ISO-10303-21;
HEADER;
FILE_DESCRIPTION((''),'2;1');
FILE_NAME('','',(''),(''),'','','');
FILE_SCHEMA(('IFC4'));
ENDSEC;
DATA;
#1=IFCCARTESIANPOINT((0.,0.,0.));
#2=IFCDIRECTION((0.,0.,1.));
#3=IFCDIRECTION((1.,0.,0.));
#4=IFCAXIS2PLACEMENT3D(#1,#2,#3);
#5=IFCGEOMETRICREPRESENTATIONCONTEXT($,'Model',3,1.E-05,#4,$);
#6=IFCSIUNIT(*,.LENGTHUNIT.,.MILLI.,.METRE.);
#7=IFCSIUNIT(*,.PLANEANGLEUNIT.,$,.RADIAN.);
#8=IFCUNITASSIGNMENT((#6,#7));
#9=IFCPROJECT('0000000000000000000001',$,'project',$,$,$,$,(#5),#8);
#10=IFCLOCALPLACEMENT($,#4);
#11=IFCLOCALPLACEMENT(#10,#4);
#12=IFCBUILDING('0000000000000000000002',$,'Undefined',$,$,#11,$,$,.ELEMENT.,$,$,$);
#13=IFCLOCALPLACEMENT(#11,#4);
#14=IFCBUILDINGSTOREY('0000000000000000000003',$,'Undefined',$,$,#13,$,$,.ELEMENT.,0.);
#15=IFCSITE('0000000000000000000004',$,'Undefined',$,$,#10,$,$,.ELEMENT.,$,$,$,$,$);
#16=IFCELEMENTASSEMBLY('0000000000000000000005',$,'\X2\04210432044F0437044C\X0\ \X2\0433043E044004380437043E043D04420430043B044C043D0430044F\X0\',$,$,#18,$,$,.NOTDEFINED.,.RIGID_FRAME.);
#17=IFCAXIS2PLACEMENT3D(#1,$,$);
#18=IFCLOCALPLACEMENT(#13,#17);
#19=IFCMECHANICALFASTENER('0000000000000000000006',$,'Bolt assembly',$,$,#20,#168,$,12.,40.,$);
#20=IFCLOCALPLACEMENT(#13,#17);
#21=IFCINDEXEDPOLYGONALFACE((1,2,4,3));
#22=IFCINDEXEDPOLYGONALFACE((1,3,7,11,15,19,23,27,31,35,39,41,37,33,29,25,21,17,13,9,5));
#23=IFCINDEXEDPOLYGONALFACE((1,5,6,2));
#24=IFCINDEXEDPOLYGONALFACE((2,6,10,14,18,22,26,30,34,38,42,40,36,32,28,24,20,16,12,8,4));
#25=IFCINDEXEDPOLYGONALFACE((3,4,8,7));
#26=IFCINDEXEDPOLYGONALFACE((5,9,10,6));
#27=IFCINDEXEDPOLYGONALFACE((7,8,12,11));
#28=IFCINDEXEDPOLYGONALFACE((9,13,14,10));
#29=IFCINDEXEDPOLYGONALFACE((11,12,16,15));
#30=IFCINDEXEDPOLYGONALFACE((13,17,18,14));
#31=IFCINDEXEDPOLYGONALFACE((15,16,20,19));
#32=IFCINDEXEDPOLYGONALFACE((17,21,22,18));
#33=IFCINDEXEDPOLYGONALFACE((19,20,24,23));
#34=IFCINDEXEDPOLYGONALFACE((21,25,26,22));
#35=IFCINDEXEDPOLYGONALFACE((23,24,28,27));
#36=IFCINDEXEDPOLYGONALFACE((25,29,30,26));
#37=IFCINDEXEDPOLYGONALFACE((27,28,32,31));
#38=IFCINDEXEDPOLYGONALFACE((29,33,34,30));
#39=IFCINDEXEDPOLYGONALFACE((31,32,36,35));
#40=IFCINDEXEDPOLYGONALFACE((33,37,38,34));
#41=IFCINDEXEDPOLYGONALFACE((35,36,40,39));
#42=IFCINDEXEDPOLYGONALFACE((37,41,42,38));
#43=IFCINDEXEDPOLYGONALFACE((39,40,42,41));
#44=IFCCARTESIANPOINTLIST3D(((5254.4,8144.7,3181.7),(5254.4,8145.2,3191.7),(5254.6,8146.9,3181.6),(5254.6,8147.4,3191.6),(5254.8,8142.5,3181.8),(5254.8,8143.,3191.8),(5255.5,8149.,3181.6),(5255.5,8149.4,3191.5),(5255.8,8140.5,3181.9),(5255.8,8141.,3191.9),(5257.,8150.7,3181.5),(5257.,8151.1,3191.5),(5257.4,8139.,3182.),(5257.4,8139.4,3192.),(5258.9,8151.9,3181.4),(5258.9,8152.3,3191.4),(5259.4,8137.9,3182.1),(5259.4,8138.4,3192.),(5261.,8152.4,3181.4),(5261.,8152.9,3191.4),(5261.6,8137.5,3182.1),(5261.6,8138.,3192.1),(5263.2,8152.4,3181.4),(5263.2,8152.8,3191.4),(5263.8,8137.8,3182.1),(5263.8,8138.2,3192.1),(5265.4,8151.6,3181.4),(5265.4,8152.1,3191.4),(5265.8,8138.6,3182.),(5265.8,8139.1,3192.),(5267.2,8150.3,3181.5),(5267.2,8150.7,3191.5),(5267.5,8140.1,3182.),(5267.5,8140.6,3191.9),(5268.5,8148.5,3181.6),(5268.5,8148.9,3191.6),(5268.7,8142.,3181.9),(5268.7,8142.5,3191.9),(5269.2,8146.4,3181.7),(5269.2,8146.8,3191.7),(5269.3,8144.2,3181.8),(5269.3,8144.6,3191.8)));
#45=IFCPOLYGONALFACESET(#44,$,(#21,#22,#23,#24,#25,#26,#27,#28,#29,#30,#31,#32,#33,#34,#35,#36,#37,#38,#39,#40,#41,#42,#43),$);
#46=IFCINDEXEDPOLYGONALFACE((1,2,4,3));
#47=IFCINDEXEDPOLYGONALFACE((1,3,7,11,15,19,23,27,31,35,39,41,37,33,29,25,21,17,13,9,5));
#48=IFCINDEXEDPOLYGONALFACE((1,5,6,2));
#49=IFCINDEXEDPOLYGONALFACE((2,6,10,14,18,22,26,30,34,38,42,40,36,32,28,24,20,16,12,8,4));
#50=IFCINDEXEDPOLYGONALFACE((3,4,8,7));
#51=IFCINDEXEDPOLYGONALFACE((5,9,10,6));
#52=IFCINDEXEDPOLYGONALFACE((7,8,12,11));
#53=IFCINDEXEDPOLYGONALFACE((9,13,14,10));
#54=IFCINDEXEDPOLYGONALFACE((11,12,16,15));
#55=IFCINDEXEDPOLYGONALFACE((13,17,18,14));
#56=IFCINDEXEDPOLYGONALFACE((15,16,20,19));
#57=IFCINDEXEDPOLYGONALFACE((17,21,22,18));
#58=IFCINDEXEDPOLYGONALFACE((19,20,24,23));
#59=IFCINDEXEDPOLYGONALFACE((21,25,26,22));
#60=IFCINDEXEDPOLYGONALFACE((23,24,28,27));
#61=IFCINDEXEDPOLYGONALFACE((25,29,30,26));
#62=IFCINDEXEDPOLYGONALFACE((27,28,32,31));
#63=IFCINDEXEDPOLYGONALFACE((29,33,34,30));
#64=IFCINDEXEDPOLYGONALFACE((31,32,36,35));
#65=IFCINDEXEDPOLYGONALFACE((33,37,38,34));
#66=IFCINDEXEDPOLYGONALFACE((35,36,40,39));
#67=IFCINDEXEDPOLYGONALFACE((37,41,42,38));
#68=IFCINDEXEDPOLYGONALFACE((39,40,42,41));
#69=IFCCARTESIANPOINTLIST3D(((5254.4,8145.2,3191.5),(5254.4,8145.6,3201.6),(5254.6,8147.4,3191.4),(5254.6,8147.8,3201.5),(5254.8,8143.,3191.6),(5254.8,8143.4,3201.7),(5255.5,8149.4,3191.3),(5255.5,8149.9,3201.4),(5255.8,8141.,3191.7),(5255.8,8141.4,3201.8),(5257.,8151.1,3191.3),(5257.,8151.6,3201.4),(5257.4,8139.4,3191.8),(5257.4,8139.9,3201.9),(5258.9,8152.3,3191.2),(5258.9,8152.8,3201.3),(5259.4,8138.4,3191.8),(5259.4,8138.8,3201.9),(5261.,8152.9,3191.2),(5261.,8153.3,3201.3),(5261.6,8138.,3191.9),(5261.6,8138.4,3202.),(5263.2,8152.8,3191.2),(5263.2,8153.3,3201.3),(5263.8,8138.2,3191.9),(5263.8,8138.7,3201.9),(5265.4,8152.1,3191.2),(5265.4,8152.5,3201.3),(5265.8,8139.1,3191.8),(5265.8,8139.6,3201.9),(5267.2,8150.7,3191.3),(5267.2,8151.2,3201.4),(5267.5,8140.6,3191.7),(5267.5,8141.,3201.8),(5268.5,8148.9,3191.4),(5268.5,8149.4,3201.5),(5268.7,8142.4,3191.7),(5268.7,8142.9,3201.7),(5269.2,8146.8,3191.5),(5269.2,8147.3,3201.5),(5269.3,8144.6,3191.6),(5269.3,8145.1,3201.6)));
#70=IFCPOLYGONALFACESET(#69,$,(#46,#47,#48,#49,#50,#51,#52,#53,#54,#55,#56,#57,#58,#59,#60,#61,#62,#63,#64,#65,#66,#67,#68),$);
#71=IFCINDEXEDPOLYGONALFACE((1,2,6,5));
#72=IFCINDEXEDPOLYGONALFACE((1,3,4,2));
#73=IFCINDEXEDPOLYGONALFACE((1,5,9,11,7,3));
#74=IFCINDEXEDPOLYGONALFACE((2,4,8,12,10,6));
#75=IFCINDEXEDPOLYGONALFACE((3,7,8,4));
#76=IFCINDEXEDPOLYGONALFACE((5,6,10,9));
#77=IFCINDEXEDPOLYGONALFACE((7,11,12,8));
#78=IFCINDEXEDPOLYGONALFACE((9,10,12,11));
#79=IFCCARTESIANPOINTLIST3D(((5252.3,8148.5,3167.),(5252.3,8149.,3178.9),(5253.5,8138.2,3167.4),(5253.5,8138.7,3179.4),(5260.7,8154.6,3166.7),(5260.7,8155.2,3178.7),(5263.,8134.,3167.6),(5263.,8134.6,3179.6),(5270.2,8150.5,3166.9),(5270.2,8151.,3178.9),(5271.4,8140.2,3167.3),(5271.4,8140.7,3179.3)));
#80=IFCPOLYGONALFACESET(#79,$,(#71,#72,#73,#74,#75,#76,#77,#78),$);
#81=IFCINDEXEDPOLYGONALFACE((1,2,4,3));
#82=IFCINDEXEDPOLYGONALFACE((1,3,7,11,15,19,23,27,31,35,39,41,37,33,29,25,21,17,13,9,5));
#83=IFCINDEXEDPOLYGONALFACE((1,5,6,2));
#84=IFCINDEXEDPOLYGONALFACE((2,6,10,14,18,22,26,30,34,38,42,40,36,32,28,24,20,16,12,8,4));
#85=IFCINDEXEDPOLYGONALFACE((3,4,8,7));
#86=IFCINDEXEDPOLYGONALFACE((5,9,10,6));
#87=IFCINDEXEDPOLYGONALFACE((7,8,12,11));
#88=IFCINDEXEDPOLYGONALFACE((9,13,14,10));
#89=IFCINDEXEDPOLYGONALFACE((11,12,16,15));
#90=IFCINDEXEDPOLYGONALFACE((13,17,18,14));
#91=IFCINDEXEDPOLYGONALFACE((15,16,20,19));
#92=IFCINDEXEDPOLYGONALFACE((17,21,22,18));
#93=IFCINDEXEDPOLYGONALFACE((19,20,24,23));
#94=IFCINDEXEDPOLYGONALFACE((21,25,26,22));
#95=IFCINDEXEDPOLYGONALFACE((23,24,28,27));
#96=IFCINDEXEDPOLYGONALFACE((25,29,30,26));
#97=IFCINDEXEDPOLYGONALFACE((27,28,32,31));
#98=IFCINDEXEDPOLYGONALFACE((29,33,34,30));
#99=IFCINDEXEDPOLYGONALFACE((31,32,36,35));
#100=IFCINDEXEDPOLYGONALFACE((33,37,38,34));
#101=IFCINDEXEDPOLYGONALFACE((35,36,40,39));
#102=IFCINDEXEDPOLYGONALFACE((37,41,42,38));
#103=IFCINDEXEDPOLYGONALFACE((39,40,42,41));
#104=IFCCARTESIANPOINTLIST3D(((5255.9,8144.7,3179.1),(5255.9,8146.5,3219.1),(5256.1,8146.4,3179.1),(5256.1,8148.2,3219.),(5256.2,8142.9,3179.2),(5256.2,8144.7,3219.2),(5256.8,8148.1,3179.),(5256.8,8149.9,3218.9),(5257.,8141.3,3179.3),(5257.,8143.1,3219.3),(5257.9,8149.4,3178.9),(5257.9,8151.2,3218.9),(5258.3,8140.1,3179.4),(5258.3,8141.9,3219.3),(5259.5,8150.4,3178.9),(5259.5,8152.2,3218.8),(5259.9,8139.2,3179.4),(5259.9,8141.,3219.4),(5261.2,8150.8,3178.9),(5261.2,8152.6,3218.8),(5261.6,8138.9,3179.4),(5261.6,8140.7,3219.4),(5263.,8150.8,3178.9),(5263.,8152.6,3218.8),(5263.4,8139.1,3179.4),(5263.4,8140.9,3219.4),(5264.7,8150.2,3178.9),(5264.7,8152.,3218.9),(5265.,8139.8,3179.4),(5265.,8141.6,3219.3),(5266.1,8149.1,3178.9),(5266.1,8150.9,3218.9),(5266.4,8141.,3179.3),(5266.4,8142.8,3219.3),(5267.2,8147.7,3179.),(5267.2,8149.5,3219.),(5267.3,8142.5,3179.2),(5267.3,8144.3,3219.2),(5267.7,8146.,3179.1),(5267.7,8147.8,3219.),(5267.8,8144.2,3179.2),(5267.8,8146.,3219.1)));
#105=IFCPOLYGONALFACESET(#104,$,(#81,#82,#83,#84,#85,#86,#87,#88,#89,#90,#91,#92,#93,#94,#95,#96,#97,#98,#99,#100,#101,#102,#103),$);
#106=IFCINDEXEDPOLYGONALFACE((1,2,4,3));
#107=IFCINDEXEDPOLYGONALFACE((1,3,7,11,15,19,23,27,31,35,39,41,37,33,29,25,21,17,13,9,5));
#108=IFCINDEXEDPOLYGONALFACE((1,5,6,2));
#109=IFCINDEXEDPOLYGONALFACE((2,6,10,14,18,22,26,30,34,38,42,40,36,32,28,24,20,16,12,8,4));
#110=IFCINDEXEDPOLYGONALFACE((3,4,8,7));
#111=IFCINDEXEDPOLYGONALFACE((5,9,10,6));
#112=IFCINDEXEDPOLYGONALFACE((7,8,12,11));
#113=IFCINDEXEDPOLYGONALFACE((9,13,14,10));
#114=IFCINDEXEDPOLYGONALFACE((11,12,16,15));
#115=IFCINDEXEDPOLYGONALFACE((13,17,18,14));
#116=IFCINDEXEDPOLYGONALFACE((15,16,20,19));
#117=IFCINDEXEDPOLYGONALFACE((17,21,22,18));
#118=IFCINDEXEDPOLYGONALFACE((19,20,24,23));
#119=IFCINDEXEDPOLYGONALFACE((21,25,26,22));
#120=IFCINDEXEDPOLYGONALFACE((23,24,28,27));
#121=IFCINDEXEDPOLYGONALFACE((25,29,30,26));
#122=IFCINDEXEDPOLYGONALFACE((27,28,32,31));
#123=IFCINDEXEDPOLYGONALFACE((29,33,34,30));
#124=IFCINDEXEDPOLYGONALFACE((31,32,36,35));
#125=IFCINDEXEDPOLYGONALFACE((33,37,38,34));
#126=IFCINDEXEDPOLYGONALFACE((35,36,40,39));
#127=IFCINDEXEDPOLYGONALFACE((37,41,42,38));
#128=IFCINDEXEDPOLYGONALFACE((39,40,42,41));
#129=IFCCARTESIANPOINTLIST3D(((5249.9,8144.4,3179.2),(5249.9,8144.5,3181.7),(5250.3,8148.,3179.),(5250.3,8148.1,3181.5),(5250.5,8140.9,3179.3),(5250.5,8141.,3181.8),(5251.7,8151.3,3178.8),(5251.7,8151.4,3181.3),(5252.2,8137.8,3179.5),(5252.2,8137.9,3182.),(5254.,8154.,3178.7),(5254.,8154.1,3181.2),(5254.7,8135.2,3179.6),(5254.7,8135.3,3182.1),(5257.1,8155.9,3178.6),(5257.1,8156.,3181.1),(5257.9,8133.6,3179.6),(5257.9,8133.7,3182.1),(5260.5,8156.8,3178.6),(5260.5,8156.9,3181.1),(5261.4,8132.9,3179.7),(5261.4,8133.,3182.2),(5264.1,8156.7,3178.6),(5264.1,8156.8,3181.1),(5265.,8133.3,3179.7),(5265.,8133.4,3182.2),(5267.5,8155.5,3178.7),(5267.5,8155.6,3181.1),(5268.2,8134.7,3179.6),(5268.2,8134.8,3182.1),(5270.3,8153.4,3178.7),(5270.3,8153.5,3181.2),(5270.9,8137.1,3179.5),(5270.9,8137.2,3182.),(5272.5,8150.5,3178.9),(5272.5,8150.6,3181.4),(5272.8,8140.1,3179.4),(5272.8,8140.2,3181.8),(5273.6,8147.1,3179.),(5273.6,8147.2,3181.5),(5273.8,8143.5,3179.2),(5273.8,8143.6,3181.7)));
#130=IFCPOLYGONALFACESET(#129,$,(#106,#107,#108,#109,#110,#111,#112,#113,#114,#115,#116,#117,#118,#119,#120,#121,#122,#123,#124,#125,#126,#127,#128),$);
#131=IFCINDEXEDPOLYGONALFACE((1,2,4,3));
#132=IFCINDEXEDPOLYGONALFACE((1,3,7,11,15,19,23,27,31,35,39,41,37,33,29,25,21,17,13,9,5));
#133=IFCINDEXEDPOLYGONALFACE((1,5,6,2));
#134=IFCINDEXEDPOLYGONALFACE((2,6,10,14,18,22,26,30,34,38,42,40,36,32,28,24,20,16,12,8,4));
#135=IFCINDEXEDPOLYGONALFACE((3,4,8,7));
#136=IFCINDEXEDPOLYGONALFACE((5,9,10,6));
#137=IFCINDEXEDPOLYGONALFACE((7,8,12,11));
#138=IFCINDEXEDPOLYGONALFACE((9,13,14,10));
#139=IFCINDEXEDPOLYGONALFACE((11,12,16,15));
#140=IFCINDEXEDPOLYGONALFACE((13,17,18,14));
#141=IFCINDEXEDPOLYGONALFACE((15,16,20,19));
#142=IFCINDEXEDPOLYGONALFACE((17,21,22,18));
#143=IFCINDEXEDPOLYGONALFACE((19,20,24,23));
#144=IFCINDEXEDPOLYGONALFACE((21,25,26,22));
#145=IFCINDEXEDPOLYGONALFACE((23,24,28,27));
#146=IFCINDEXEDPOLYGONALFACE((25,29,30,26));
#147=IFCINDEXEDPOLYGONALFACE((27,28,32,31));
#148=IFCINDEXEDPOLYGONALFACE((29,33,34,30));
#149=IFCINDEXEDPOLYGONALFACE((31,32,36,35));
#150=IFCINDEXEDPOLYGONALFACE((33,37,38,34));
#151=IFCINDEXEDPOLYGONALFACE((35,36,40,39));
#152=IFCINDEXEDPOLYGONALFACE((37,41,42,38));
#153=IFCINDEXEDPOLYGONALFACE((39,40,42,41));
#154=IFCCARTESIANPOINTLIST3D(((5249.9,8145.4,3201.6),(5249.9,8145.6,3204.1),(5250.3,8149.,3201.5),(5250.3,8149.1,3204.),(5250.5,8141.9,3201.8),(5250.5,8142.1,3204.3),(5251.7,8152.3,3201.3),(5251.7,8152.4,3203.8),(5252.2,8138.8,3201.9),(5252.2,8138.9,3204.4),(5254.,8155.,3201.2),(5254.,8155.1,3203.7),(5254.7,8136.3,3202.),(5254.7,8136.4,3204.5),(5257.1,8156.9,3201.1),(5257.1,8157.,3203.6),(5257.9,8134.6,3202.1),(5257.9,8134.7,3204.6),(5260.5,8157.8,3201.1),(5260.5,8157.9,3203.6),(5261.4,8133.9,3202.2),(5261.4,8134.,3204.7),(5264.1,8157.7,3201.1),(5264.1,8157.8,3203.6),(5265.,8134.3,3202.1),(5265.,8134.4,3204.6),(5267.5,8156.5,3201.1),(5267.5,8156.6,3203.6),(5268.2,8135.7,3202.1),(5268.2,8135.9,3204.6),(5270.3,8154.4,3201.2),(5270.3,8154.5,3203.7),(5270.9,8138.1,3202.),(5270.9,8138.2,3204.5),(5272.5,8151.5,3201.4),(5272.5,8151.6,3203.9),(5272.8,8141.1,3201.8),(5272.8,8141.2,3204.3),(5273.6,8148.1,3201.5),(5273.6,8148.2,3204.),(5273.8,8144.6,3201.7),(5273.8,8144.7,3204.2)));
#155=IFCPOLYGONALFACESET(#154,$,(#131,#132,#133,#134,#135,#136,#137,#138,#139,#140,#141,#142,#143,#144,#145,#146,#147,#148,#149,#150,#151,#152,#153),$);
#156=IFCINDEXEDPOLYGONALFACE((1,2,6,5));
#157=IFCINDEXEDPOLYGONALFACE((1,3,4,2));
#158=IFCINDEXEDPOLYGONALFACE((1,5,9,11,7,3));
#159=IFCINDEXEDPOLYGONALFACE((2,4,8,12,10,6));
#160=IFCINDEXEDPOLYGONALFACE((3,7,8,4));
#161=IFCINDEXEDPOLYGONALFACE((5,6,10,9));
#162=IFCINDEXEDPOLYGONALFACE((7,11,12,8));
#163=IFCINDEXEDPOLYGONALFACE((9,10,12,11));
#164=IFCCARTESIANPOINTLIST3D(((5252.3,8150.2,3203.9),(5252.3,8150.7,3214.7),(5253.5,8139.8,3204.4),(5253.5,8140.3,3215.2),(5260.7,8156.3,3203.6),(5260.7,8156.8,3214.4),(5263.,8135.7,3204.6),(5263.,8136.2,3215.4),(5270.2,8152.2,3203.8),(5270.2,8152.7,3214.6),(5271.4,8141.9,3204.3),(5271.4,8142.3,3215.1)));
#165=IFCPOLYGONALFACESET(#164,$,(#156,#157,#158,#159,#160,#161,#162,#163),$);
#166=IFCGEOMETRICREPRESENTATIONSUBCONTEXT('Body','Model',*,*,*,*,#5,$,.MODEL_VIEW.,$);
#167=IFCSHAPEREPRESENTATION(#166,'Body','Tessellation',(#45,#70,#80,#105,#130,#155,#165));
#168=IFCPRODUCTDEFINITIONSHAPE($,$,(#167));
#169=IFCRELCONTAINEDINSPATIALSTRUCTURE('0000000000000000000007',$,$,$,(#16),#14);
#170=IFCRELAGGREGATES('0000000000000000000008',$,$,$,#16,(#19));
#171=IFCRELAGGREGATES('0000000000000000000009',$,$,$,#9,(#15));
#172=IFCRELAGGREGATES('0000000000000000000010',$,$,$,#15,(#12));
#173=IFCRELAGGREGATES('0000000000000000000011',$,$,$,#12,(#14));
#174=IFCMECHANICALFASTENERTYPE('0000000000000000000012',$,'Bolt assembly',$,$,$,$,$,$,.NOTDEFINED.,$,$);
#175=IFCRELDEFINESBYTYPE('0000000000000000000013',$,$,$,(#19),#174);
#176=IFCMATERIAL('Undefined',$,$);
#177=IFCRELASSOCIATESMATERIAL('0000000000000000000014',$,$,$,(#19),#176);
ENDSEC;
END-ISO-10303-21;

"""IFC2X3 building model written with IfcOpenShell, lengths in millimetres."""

from ifc_helpers import new_model, si_unit, frame, origin_with_axes, origin_2d_with_axis, place, context, subcontext, project, spatial, polyline, circle, outline, extrude, source, transform, mapped, material, type_object, element, aggregate, save


model = new_model("IFC2X3")

# Units and contexts
model_context = context("Model", 3, precision=1e-05, world=origin_with_axes())
body_context = subcontext(model_context, "Body", "Model", "MODEL_VIEW")
ifc_project = project(units=[si_unit("LENGTHUNIT", "METRE", prefix="MILLI"), si_unit("PLANEANGLEUNIT", "RADIAN")], contexts=[model_context])

# Site, building, storey
site_placement = place(None, origin_with_axes())
site = spatial("IfcSite", under=ifc_project, at=site_placement, Name="Undefined", CompositionType="ELEMENT")
building_placement = place(site_placement, origin_with_axes())
building = spatial("IfcBuilding", under=site, at=building_placement, Name="Undefined", CompositionType="ELEMENT")
storey_placement = place(building_placement, origin_with_axes())
storey = spatial("IfcBuildingStorey", under=building, at=storey_placement, Name="Undefined", CompositionType="ELEMENT", Elevation=0.0)

# Element assembly
assembly_1_placement = place(storey_placement, origin_with_axes())
assembly_1 = element("IfcElementAssembly", 1, at=assembly_1_placement, inside=storey, Name="Связь горизонтальная", AssemblyPlace="NOTDEFINED", PredefinedType="RIGID_FRAME")

# Mechanical fastener
ifc_material_1 = material(Name="Undefined")
mechanical_fastener_type = type_object("IfcMechanicalFastenerType", Name="Bolt assembly")
shared_shape_1 = source(origin_with_axes(), body_context, "Body", "SweptSolid", [
    extrude(circle(Radius=7.5, at=origin_2d_with_axis()), frame((0.0, 0.1, 0.0), z_axis=(0.0, 1.0, 0.0), x_axis=(1.0, 0.0, 0.0)), (0.0, 0.0, 1.0), 10.0),
    extrude(circle(Radius=7.5, at=origin_2d_with_axis()), frame((0.0, 9.9, 0.0), z_axis=(0.0, 1.0, 0.0), x_axis=(1.0, 0.0, 0.0)), (0.0, 0.0, 1.0), 10.1),
    extrude(outline(polyline([(10.4, 0.0), (5.2, 9.0), (-5.2, 9.0), (-10.4, 0.0), (-5.2, -9.0), (5.2, -9.0), (10.4, 0.0)])), frame((0.0, -14.5, 0.0), z_axis=(0.0, 1.0, 0.0), x_axis=(1.0, 0.0, 0.0)), (0.0, 0.0, 1.0), 12.0),
    extrude(circle(Radius=6.0, at=origin_2d_with_axis()), frame((0.0, -2.5, 0.0), z_axis=(0.0, 1.0, 0.0), x_axis=(1.0, 0.0, 0.0)), (0.0, 0.0, 1.0), 40.0),
    extrude(circle(Radius=12.0, at=origin_2d_with_axis()), frame((0.0, -2.5, 0.0), z_axis=(0.0, 1.0, 0.0), x_axis=(1.0, 0.0, 0.0)), (0.0, 0.0, 1.0), 2.5),
    extrude(circle(Radius=12.0, at=origin_2d_with_axis()), frame((0.0, 20.0, 0.0), z_axis=(0.0, 1.0, 0.0), x_axis=(1.0, 0.0, 0.0)), (0.0, 0.0, 1.0), 2.5),
    extrude(outline(polyline([(10.4, 0.0), (5.2, 9.0), (-5.2, 9.0), (-10.4, 0.0), (-5.2, -9.0), (5.2, -9.0), (10.4, 0.0)])), frame((0.0, 22.5, 0.0), z_axis=(0.0, 1.0, 0.0), x_axis=(1.0, 0.0, 0.0)), (0.0, 0.0, 1.0), 10.8),
])
mechanical_fastener_1_placement = place(assembly_1_placement, frame((5261.9, 8145.0, 3181.6), z_axis=(-0.593795, 0.803786, -0.036536), x_axis=(-0.804616, -0.593183, 0.026963)))
mechanical_fastener_1 = element("IfcMechanicalFastener", 2, at=mechanical_fastener_1_placement, type_object=mechanical_fastener_type, material=ifc_material_1, Name="Bolt assembly", NominalDiameter=12.0, NominalLength=40.0, context=body_context, shape_type="MappedRepresentation", body=[
    mapped(shared_shape_1, transform((0.0, 0.0, 0.0))),
])
aggregate(assembly_1, [mechanical_fastener_1])

save(model, "model.ifc")
